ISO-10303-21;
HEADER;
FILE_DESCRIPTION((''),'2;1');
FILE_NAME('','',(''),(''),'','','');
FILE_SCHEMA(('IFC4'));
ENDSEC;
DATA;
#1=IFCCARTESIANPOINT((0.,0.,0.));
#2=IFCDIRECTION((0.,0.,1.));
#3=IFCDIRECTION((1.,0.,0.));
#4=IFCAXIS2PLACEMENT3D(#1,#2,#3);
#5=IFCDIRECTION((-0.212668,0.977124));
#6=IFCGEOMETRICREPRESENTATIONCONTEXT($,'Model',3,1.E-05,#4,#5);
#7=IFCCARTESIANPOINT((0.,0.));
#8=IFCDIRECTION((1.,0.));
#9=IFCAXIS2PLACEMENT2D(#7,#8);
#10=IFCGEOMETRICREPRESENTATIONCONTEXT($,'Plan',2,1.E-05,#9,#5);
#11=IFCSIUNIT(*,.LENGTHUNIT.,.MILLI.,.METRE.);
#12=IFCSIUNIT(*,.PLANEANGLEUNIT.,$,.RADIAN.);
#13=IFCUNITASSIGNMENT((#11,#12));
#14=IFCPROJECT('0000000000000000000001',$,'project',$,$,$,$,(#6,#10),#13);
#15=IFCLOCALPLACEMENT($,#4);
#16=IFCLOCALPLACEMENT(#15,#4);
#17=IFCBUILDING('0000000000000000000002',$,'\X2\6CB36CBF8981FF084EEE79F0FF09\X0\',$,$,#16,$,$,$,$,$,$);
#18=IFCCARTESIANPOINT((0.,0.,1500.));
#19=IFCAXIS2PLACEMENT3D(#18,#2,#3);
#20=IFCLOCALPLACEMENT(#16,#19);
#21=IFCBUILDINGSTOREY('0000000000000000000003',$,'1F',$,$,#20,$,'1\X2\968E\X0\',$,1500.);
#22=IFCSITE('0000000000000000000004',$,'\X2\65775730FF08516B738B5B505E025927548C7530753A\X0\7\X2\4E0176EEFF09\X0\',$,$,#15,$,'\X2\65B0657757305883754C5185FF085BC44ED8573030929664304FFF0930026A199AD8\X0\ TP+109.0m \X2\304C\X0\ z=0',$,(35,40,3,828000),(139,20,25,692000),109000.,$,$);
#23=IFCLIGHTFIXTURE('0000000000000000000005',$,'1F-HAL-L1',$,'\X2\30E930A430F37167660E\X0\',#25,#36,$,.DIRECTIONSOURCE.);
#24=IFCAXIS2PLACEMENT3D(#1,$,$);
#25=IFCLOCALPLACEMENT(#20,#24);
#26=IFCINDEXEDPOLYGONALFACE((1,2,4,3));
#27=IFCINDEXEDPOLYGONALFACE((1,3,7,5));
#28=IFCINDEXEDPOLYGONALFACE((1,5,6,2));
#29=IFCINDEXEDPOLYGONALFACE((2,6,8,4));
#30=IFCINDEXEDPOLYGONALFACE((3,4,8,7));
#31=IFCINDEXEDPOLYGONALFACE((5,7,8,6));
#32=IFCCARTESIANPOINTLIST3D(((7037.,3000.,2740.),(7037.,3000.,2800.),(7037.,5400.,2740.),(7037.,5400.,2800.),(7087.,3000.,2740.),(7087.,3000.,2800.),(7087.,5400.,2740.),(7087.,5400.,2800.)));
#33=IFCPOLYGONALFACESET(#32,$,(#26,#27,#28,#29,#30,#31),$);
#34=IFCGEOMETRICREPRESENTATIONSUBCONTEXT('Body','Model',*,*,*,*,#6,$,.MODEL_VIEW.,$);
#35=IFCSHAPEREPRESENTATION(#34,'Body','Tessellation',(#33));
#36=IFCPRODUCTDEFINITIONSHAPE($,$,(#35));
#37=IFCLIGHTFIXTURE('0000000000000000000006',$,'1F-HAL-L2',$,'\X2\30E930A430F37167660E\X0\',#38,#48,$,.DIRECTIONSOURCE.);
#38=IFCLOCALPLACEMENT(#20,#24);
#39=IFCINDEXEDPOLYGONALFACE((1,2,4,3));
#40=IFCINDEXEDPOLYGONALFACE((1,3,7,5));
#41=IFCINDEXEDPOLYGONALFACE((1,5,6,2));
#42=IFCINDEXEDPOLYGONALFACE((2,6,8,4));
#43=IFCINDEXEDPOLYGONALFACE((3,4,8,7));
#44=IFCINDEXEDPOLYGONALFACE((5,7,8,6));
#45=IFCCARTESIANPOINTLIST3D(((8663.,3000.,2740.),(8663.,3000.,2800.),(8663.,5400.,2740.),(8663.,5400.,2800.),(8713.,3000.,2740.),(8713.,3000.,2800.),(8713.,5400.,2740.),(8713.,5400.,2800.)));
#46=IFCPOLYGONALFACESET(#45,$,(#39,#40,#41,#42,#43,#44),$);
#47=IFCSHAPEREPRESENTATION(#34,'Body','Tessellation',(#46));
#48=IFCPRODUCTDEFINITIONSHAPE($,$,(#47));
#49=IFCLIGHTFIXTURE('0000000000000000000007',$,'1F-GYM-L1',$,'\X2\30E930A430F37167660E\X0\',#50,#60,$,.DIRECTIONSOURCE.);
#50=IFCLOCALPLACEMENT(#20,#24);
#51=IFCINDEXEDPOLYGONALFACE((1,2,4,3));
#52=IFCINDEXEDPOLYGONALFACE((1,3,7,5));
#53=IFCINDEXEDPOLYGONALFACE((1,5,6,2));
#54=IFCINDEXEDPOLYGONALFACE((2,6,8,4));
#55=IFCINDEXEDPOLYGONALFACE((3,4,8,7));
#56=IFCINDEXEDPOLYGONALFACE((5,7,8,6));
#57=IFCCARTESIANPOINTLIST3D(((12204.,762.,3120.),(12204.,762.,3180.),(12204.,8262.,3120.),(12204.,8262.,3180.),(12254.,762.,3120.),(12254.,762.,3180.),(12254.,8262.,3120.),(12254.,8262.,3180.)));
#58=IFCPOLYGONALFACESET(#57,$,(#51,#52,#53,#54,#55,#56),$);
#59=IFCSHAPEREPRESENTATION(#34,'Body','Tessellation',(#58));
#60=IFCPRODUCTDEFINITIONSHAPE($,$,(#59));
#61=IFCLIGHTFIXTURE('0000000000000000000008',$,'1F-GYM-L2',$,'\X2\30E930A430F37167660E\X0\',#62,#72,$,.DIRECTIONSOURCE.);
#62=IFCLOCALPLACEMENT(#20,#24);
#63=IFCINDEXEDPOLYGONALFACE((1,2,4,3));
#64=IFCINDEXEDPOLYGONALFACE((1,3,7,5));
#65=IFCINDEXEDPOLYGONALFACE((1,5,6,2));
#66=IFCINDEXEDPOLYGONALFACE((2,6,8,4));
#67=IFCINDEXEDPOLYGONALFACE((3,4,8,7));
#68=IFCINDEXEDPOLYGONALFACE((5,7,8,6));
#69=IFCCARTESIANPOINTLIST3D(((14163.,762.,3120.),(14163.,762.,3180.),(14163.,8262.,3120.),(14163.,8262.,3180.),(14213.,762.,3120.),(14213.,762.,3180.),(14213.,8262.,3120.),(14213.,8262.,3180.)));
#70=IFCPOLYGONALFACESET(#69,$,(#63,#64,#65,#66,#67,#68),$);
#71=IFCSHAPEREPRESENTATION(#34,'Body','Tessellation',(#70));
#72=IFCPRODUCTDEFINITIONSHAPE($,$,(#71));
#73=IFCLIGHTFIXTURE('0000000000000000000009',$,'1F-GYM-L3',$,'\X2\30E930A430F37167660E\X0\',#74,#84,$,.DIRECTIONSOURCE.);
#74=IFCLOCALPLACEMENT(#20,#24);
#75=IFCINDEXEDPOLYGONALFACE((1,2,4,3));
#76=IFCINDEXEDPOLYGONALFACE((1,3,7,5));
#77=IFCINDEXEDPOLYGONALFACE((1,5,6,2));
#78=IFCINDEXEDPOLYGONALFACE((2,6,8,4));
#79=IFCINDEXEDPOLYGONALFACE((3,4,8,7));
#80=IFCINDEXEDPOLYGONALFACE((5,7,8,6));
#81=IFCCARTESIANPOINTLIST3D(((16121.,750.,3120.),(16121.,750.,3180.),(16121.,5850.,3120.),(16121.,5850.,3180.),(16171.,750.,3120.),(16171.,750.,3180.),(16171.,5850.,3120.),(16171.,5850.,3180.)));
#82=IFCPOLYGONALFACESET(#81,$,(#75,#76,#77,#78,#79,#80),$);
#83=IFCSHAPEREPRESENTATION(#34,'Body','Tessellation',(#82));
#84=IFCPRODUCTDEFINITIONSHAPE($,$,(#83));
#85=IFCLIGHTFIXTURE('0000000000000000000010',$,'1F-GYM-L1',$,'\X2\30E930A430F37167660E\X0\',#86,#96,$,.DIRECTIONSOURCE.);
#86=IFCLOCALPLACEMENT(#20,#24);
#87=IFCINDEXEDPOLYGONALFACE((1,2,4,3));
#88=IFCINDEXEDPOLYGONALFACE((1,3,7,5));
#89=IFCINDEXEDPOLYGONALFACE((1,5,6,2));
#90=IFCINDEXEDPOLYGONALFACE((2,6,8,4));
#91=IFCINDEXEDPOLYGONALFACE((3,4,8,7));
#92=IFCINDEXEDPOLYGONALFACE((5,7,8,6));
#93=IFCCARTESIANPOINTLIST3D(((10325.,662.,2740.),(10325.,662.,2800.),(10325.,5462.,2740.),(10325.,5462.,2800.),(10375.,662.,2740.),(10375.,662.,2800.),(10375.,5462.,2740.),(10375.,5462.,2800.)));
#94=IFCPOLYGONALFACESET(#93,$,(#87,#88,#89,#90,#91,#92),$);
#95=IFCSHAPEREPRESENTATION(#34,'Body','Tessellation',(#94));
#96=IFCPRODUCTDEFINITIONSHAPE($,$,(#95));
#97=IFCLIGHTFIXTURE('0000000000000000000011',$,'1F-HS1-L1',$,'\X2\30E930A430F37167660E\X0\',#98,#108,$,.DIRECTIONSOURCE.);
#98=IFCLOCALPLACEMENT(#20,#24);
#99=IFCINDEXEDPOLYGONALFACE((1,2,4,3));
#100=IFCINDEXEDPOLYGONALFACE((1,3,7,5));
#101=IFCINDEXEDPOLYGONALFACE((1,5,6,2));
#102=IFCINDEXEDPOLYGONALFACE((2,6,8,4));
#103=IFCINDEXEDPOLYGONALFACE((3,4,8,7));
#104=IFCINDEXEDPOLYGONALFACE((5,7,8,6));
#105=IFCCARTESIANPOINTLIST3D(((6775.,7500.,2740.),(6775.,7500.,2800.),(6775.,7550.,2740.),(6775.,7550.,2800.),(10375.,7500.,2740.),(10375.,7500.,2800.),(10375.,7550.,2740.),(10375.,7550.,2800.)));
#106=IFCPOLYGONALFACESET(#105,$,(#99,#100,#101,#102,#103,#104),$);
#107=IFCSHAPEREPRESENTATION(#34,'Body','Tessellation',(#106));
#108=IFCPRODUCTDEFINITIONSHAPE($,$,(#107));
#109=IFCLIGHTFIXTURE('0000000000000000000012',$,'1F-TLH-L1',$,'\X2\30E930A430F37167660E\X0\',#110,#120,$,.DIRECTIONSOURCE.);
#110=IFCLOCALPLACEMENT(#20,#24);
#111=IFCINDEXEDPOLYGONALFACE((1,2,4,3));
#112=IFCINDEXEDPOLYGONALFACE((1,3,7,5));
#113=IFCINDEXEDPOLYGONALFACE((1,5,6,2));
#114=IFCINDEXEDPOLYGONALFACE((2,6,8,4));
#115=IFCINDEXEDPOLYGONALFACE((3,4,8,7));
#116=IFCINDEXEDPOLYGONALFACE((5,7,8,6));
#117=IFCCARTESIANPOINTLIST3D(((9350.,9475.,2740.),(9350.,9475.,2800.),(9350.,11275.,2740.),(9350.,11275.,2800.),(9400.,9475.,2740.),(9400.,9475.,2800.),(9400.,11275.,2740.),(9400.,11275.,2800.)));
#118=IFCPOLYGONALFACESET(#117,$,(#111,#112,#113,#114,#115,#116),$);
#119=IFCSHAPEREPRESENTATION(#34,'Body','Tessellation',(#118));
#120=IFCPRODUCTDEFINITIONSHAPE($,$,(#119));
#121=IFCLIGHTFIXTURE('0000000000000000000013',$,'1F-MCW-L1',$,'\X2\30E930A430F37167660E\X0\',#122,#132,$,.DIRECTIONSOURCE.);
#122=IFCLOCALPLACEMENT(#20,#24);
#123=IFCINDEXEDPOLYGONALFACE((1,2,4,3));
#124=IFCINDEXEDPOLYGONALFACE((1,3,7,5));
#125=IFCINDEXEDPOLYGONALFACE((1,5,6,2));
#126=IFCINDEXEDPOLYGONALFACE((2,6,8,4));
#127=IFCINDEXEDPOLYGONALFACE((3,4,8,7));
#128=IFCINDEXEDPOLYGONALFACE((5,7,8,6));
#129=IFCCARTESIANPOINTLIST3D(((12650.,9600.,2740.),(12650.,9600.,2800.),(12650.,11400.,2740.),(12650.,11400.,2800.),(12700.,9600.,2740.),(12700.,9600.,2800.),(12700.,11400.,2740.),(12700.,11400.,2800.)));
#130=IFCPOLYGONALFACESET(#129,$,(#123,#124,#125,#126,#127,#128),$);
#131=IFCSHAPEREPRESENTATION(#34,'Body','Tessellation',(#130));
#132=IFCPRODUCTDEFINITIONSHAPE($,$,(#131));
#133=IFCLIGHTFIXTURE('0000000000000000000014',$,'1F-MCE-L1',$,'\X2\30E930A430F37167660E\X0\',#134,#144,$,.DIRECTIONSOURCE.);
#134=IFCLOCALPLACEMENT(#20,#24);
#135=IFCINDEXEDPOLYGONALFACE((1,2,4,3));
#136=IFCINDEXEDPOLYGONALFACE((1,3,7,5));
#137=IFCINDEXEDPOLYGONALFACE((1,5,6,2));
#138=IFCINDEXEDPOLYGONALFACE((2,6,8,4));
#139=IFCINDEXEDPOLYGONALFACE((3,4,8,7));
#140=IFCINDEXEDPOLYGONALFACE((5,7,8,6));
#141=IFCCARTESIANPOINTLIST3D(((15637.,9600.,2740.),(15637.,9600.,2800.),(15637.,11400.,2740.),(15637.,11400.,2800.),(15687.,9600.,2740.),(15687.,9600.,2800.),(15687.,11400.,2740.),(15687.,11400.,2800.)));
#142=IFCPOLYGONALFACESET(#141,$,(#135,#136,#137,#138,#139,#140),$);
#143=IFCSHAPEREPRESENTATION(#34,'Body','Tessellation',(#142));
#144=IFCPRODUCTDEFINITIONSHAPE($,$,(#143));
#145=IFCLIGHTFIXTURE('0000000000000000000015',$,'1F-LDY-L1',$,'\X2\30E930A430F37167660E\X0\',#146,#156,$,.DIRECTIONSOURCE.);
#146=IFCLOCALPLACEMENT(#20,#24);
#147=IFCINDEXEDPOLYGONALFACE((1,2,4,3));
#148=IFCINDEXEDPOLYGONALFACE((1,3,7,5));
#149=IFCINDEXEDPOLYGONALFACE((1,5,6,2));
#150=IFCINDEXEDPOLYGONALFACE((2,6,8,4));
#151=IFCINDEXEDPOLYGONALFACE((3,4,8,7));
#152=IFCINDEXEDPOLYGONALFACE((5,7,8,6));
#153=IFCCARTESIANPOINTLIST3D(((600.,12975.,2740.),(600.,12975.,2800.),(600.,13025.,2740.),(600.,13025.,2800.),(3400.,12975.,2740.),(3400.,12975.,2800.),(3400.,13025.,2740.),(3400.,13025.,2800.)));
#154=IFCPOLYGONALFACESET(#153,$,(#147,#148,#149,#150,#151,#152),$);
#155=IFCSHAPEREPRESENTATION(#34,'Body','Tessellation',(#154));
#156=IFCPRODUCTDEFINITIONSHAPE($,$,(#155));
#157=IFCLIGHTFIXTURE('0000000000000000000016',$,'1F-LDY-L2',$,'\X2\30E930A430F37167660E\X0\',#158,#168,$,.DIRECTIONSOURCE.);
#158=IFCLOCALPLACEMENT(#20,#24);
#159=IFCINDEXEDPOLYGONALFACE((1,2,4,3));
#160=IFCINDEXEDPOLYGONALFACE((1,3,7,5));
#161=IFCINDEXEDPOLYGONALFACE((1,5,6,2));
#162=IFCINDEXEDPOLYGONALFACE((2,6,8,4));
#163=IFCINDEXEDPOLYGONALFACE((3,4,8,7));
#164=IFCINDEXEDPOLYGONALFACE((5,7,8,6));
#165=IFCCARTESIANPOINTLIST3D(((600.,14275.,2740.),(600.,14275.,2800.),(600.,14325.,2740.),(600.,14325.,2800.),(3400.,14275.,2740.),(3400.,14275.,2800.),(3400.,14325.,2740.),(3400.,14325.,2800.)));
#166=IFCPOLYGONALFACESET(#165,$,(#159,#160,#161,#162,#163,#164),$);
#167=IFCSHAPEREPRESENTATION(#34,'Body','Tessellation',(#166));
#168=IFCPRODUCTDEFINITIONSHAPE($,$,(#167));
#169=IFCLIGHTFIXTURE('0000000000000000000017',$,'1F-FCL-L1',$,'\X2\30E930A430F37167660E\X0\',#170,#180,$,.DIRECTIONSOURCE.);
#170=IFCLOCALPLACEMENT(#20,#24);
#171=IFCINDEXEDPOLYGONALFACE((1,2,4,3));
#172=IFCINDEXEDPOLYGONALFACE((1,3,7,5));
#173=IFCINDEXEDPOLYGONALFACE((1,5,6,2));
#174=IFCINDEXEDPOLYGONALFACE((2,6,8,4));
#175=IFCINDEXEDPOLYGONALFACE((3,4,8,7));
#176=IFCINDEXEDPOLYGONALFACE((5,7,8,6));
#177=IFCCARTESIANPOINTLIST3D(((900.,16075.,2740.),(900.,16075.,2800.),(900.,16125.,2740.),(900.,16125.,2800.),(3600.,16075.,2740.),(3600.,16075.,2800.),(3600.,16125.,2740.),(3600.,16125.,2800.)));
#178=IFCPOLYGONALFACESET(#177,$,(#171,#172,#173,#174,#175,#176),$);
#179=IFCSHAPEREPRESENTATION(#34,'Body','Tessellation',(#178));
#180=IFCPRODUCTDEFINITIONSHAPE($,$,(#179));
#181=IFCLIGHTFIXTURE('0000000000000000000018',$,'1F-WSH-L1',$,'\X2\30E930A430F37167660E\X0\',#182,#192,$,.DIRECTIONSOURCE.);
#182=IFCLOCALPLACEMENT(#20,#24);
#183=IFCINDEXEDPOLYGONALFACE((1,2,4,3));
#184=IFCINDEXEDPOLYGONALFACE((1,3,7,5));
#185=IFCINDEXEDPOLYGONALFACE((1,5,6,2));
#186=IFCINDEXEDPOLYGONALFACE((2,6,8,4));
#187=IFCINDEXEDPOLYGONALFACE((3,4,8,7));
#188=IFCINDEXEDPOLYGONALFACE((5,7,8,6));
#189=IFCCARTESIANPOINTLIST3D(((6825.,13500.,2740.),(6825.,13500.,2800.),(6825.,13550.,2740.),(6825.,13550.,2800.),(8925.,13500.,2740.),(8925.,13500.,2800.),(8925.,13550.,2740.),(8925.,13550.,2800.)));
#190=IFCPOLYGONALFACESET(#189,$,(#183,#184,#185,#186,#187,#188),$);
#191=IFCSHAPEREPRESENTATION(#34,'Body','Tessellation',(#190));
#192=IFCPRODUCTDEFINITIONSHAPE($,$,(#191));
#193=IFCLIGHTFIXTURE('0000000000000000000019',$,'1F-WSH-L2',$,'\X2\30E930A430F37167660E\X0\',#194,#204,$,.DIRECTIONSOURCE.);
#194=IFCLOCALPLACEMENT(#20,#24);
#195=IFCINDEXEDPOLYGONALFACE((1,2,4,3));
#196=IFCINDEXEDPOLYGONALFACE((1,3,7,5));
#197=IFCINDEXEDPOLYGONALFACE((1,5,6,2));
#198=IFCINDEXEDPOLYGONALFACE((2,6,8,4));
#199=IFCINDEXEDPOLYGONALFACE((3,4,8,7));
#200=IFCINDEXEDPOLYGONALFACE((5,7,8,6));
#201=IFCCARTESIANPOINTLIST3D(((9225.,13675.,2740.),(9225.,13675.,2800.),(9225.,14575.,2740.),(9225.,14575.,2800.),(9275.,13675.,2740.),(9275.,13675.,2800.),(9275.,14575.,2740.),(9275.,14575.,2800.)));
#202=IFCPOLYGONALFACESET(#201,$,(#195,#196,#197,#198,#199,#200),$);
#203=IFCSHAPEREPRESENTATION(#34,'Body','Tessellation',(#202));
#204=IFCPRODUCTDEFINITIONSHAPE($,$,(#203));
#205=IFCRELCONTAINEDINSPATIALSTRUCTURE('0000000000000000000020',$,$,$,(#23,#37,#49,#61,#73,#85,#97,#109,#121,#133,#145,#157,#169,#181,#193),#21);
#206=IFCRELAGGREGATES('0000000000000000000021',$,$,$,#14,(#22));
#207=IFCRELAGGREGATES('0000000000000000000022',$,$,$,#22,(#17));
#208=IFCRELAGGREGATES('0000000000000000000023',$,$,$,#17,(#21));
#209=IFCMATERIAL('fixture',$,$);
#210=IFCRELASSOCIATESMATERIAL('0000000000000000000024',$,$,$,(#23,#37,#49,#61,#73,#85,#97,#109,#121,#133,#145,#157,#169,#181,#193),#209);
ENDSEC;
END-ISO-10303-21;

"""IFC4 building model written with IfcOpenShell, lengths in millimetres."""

from ifc_helpers import new_model, si_unit, direction, frame, frame_2d, origin_with_axes, origin_2d_with_axis, place, context, subcontext, project, spatial, rectangle, extrude, material, element, save


model = new_model("IFC4")

# Units and contexts
model_context = context("Model", 3, precision=1e-05, world=origin_with_axes(), true_north=direction((-0.212668, 0.977124)))
plan_context = context("Plan", 2, precision=1e-05, world=origin_2d_with_axis(), true_north=direction((-0.212668, 0.977124)))
body_context = subcontext(model_context, "Body", "Model", "MODEL_VIEW")
ifc_project = project(units=[si_unit("LENGTHUNIT", "METRE", prefix="MILLI"), si_unit("PLANEANGLEUNIT", "RADIAN")], contexts=[model_context, plan_context])

# Site, building, storey
site_placement = place(None, origin_with_axes())
site = spatial("IfcSite", under=ifc_project, at=site_placement, Name="敷地（八王子市大和田町7丁目）", LongName="新敷地境界内（寄付地を除く）。標高 TP+109.0m が z=0", RefLatitude=(35, 40, 3, 828000), RefLongitude=(139, 20, 25, 692000), RefElevation=109000.0)
building_placement = place(site_placement, origin_with_axes())
building = spatial("IfcBuilding", under=site, at=building_placement, Name="河沿要（仮称）")
storey_placement = place(building_placement, frame((0.0, 0.0, 1500.0), z_axis=(0.0, 0.0, 1.0), x_axis=(1.0, 0.0, 0.0)))
storey = spatial("IfcBuildingStorey", under=building, at=storey_placement, Name="1F", LongName="1階", Elevation=1500.0)

# Light fixtures
ifc_material = material(Name="fixture")
light_fixture_1_placement = place(storey_placement, origin_with_axes())
element("IfcLightFixture", 1, at=light_fixture_1_placement, inside=storey, material=ifc_material, Name="1F-HAL-L1", ObjectType="ライン照明", PredefinedType="DIRECTIONSOURCE", context=body_context, shape_type="SweptSolid", body=[
    extrude(rectangle(XDim=50.0, YDim=2400.0, at=frame_2d((7062.0, 4200.0))), frame((0.0, 0.0, 2740.0)), (0.0, 0.0, 1.0), 60.0),
])
light_fixture_2_placement = place(storey_placement, origin_with_axes())
element("IfcLightFixture", 2, at=light_fixture_2_placement, inside=storey, material=ifc_material, Name="1F-HAL-L2", ObjectType="ライン照明", PredefinedType="DIRECTIONSOURCE", context=body_context, shape_type="SweptSolid", body=[
    extrude(rectangle(XDim=50.0, YDim=2400.0, at=frame_2d((8688.0, 4200.0))), frame((0.0, 0.0, 2740.0)), (0.0, 0.0, 1.0), 60.0),
])
light_fixture_3_placement = place(storey_placement, origin_with_axes())
element("IfcLightFixture", 3, at=light_fixture_3_placement, inside=storey, material=ifc_material, Name="1F-GYM-L1", ObjectType="ライン照明", PredefinedType="DIRECTIONSOURCE", context=body_context, shape_type="SweptSolid", body=[
    extrude(rectangle(XDim=50.0, YDim=7500.0, at=frame_2d((12229.0, 4512.0))), frame((0.0, 0.0, 3120.0)), (0.0, 0.0, 1.0), 60.0),
])
light_fixture_4_placement = place(storey_placement, origin_with_axes())
element("IfcLightFixture", 4, at=light_fixture_4_placement, inside=storey, material=ifc_material, Name="1F-GYM-L2", ObjectType="ライン照明", PredefinedType="DIRECTIONSOURCE", context=body_context, shape_type="SweptSolid", body=[
    extrude(rectangle(XDim=50.0, YDim=7500.0, at=frame_2d((14188.0, 4512.0))), frame((0.0, 0.0, 3120.0)), (0.0, 0.0, 1.0), 60.0),
])
light_fixture_5_placement = place(storey_placement, origin_with_axes())
element("IfcLightFixture", 5, at=light_fixture_5_placement, inside=storey, material=ifc_material, Name="1F-GYM-L3", ObjectType="ライン照明", PredefinedType="DIRECTIONSOURCE", context=body_context, shape_type="SweptSolid", body=[
    extrude(rectangle(XDim=50.0, YDim=5100.0, at=frame_2d((16146.0, 3300.0))), frame((0.0, 0.0, 3120.0)), (0.0, 0.0, 1.0), 60.0),
])
light_fixture_6_placement = place(storey_placement, origin_with_axes())
element("IfcLightFixture", 6, at=light_fixture_6_placement, inside=storey, material=ifc_material, Name="1F-GYM-L1", ObjectType="ライン照明", PredefinedType="DIRECTIONSOURCE", context=body_context, shape_type="SweptSolid", body=[
    extrude(rectangle(XDim=50.0, YDim=4800.0, at=frame_2d((10350.0, 3062.0))), frame((0.0, 0.0, 2740.0)), (0.0, 0.0, 1.0), 60.0),
])
light_fixture_7_placement = place(storey_placement, origin_with_axes())
element("IfcLightFixture", 7, at=light_fixture_7_placement, inside=storey, material=ifc_material, Name="1F-HS1-L1", ObjectType="ライン照明", PredefinedType="DIRECTIONSOURCE", context=body_context, shape_type="SweptSolid", body=[
    extrude(rectangle(XDim=3600.0, YDim=50.0, at=frame_2d((8575.0, 7525.0))), frame((0.0, 0.0, 2740.0)), (0.0, 0.0, 1.0), 60.0),
])
light_fixture_8_placement = place(storey_placement, origin_with_axes())
element("IfcLightFixture", 8, at=light_fixture_8_placement, inside=storey, material=ifc_material, Name="1F-TLH-L1", ObjectType="ライン照明", PredefinedType="DIRECTIONSOURCE", context=body_context, shape_type="SweptSolid", body=[
    extrude(rectangle(XDim=50.0, YDim=1800.0, at=frame_2d((9375.0, 10375.0))), frame((0.0, 0.0, 2740.0)), (0.0, 0.0, 1.0), 60.0),
])
light_fixture_9_placement = place(storey_placement, origin_with_axes())
element("IfcLightFixture", 9, at=light_fixture_9_placement, inside=storey, material=ifc_material, Name="1F-MCW-L1", ObjectType="ライン照明", PredefinedType="DIRECTIONSOURCE", context=body_context, shape_type="SweptSolid", body=[
    extrude(rectangle(XDim=50.0, YDim=1800.0, at=frame_2d((12675.0, 10500.0))), frame((0.0, 0.0, 2740.0)), (0.0, 0.0, 1.0), 60.0),
])
light_fixture_10_placement = place(storey_placement, origin_with_axes())
element("IfcLightFixture", 10, at=light_fixture_10_placement, inside=storey, material=ifc_material, Name="1F-MCE-L1", ObjectType="ライン照明", PredefinedType="DIRECTIONSOURCE", context=body_context, shape_type="SweptSolid", body=[
    extrude(rectangle(XDim=50.0, YDim=1800.0, at=frame_2d((15662.0, 10500.0))), frame((0.0, 0.0, 2740.0)), (0.0, 0.0, 1.0), 60.0),
])
light_fixture_11_placement = place(storey_placement, origin_with_axes())
element("IfcLightFixture", 11, at=light_fixture_11_placement, inside=storey, material=ifc_material, Name="1F-LDY-L1", ObjectType="ライン照明", PredefinedType="DIRECTIONSOURCE", context=body_context, shape_type="SweptSolid", body=[
    extrude(rectangle(XDim=2800.0, YDim=50.0, at=frame_2d((2000.0, 13000.0))), frame((0.0, 0.0, 2740.0)), (0.0, 0.0, 1.0), 60.0),
])
light_fixture_12_placement = place(storey_placement, origin_with_axes())
element("IfcLightFixture", 12, at=light_fixture_12_placement, inside=storey, material=ifc_material, Name="1F-LDY-L2", ObjectType="ライン照明", PredefinedType="DIRECTIONSOURCE", context=body_context, shape_type="SweptSolid", body=[
    extrude(rectangle(XDim=2800.0, YDim=50.0, at=frame_2d((2000.0, 14300.0))), frame((0.0, 0.0, 2740.0)), (0.0, 0.0, 1.0), 60.0),
])
light_fixture_13_placement = place(storey_placement, origin_with_axes())
element("IfcLightFixture", 13, at=light_fixture_13_placement, inside=storey, material=ifc_material, Name="1F-FCL-L1", ObjectType="ライン照明", PredefinedType="DIRECTIONSOURCE", context=body_context, shape_type="SweptSolid", body=[
    extrude(rectangle(XDim=2700.0, YDim=50.0, at=frame_2d((2250.0, 16100.0))), frame((0.0, 0.0, 2740.0)), (0.0, 0.0, 1.0), 60.0),
])
light_fixture_14_placement = place(storey_placement, origin_with_axes())
element("IfcLightFixture", 14, at=light_fixture_14_placement, inside=storey, material=ifc_material, Name="1F-WSH-L1", ObjectType="ライン照明", PredefinedType="DIRECTIONSOURCE", context=body_context, shape_type="SweptSolid", body=[
    extrude(rectangle(XDim=2100.0, YDim=50.0, at=frame_2d((7875.0, 13525.0))), frame((0.0, 0.0, 2740.0)), (0.0, 0.0, 1.0), 60.0),
])
light_fixture_15_placement = place(storey_placement, origin_with_axes())
element("IfcLightFixture", 15, at=light_fixture_15_placement, inside=storey, material=ifc_material, Name="1F-WSH-L2", ObjectType="ライン照明", PredefinedType="DIRECTIONSOURCE", context=body_context, shape_type="SweptSolid", body=[
    extrude(rectangle(XDim=50.0, YDim=900.0, at=frame_2d((9250.0, 14125.0))), frame((0.0, 0.0, 2740.0)), (0.0, 0.0, 1.0), 60.0),
])

save(model, "model.ifc")
